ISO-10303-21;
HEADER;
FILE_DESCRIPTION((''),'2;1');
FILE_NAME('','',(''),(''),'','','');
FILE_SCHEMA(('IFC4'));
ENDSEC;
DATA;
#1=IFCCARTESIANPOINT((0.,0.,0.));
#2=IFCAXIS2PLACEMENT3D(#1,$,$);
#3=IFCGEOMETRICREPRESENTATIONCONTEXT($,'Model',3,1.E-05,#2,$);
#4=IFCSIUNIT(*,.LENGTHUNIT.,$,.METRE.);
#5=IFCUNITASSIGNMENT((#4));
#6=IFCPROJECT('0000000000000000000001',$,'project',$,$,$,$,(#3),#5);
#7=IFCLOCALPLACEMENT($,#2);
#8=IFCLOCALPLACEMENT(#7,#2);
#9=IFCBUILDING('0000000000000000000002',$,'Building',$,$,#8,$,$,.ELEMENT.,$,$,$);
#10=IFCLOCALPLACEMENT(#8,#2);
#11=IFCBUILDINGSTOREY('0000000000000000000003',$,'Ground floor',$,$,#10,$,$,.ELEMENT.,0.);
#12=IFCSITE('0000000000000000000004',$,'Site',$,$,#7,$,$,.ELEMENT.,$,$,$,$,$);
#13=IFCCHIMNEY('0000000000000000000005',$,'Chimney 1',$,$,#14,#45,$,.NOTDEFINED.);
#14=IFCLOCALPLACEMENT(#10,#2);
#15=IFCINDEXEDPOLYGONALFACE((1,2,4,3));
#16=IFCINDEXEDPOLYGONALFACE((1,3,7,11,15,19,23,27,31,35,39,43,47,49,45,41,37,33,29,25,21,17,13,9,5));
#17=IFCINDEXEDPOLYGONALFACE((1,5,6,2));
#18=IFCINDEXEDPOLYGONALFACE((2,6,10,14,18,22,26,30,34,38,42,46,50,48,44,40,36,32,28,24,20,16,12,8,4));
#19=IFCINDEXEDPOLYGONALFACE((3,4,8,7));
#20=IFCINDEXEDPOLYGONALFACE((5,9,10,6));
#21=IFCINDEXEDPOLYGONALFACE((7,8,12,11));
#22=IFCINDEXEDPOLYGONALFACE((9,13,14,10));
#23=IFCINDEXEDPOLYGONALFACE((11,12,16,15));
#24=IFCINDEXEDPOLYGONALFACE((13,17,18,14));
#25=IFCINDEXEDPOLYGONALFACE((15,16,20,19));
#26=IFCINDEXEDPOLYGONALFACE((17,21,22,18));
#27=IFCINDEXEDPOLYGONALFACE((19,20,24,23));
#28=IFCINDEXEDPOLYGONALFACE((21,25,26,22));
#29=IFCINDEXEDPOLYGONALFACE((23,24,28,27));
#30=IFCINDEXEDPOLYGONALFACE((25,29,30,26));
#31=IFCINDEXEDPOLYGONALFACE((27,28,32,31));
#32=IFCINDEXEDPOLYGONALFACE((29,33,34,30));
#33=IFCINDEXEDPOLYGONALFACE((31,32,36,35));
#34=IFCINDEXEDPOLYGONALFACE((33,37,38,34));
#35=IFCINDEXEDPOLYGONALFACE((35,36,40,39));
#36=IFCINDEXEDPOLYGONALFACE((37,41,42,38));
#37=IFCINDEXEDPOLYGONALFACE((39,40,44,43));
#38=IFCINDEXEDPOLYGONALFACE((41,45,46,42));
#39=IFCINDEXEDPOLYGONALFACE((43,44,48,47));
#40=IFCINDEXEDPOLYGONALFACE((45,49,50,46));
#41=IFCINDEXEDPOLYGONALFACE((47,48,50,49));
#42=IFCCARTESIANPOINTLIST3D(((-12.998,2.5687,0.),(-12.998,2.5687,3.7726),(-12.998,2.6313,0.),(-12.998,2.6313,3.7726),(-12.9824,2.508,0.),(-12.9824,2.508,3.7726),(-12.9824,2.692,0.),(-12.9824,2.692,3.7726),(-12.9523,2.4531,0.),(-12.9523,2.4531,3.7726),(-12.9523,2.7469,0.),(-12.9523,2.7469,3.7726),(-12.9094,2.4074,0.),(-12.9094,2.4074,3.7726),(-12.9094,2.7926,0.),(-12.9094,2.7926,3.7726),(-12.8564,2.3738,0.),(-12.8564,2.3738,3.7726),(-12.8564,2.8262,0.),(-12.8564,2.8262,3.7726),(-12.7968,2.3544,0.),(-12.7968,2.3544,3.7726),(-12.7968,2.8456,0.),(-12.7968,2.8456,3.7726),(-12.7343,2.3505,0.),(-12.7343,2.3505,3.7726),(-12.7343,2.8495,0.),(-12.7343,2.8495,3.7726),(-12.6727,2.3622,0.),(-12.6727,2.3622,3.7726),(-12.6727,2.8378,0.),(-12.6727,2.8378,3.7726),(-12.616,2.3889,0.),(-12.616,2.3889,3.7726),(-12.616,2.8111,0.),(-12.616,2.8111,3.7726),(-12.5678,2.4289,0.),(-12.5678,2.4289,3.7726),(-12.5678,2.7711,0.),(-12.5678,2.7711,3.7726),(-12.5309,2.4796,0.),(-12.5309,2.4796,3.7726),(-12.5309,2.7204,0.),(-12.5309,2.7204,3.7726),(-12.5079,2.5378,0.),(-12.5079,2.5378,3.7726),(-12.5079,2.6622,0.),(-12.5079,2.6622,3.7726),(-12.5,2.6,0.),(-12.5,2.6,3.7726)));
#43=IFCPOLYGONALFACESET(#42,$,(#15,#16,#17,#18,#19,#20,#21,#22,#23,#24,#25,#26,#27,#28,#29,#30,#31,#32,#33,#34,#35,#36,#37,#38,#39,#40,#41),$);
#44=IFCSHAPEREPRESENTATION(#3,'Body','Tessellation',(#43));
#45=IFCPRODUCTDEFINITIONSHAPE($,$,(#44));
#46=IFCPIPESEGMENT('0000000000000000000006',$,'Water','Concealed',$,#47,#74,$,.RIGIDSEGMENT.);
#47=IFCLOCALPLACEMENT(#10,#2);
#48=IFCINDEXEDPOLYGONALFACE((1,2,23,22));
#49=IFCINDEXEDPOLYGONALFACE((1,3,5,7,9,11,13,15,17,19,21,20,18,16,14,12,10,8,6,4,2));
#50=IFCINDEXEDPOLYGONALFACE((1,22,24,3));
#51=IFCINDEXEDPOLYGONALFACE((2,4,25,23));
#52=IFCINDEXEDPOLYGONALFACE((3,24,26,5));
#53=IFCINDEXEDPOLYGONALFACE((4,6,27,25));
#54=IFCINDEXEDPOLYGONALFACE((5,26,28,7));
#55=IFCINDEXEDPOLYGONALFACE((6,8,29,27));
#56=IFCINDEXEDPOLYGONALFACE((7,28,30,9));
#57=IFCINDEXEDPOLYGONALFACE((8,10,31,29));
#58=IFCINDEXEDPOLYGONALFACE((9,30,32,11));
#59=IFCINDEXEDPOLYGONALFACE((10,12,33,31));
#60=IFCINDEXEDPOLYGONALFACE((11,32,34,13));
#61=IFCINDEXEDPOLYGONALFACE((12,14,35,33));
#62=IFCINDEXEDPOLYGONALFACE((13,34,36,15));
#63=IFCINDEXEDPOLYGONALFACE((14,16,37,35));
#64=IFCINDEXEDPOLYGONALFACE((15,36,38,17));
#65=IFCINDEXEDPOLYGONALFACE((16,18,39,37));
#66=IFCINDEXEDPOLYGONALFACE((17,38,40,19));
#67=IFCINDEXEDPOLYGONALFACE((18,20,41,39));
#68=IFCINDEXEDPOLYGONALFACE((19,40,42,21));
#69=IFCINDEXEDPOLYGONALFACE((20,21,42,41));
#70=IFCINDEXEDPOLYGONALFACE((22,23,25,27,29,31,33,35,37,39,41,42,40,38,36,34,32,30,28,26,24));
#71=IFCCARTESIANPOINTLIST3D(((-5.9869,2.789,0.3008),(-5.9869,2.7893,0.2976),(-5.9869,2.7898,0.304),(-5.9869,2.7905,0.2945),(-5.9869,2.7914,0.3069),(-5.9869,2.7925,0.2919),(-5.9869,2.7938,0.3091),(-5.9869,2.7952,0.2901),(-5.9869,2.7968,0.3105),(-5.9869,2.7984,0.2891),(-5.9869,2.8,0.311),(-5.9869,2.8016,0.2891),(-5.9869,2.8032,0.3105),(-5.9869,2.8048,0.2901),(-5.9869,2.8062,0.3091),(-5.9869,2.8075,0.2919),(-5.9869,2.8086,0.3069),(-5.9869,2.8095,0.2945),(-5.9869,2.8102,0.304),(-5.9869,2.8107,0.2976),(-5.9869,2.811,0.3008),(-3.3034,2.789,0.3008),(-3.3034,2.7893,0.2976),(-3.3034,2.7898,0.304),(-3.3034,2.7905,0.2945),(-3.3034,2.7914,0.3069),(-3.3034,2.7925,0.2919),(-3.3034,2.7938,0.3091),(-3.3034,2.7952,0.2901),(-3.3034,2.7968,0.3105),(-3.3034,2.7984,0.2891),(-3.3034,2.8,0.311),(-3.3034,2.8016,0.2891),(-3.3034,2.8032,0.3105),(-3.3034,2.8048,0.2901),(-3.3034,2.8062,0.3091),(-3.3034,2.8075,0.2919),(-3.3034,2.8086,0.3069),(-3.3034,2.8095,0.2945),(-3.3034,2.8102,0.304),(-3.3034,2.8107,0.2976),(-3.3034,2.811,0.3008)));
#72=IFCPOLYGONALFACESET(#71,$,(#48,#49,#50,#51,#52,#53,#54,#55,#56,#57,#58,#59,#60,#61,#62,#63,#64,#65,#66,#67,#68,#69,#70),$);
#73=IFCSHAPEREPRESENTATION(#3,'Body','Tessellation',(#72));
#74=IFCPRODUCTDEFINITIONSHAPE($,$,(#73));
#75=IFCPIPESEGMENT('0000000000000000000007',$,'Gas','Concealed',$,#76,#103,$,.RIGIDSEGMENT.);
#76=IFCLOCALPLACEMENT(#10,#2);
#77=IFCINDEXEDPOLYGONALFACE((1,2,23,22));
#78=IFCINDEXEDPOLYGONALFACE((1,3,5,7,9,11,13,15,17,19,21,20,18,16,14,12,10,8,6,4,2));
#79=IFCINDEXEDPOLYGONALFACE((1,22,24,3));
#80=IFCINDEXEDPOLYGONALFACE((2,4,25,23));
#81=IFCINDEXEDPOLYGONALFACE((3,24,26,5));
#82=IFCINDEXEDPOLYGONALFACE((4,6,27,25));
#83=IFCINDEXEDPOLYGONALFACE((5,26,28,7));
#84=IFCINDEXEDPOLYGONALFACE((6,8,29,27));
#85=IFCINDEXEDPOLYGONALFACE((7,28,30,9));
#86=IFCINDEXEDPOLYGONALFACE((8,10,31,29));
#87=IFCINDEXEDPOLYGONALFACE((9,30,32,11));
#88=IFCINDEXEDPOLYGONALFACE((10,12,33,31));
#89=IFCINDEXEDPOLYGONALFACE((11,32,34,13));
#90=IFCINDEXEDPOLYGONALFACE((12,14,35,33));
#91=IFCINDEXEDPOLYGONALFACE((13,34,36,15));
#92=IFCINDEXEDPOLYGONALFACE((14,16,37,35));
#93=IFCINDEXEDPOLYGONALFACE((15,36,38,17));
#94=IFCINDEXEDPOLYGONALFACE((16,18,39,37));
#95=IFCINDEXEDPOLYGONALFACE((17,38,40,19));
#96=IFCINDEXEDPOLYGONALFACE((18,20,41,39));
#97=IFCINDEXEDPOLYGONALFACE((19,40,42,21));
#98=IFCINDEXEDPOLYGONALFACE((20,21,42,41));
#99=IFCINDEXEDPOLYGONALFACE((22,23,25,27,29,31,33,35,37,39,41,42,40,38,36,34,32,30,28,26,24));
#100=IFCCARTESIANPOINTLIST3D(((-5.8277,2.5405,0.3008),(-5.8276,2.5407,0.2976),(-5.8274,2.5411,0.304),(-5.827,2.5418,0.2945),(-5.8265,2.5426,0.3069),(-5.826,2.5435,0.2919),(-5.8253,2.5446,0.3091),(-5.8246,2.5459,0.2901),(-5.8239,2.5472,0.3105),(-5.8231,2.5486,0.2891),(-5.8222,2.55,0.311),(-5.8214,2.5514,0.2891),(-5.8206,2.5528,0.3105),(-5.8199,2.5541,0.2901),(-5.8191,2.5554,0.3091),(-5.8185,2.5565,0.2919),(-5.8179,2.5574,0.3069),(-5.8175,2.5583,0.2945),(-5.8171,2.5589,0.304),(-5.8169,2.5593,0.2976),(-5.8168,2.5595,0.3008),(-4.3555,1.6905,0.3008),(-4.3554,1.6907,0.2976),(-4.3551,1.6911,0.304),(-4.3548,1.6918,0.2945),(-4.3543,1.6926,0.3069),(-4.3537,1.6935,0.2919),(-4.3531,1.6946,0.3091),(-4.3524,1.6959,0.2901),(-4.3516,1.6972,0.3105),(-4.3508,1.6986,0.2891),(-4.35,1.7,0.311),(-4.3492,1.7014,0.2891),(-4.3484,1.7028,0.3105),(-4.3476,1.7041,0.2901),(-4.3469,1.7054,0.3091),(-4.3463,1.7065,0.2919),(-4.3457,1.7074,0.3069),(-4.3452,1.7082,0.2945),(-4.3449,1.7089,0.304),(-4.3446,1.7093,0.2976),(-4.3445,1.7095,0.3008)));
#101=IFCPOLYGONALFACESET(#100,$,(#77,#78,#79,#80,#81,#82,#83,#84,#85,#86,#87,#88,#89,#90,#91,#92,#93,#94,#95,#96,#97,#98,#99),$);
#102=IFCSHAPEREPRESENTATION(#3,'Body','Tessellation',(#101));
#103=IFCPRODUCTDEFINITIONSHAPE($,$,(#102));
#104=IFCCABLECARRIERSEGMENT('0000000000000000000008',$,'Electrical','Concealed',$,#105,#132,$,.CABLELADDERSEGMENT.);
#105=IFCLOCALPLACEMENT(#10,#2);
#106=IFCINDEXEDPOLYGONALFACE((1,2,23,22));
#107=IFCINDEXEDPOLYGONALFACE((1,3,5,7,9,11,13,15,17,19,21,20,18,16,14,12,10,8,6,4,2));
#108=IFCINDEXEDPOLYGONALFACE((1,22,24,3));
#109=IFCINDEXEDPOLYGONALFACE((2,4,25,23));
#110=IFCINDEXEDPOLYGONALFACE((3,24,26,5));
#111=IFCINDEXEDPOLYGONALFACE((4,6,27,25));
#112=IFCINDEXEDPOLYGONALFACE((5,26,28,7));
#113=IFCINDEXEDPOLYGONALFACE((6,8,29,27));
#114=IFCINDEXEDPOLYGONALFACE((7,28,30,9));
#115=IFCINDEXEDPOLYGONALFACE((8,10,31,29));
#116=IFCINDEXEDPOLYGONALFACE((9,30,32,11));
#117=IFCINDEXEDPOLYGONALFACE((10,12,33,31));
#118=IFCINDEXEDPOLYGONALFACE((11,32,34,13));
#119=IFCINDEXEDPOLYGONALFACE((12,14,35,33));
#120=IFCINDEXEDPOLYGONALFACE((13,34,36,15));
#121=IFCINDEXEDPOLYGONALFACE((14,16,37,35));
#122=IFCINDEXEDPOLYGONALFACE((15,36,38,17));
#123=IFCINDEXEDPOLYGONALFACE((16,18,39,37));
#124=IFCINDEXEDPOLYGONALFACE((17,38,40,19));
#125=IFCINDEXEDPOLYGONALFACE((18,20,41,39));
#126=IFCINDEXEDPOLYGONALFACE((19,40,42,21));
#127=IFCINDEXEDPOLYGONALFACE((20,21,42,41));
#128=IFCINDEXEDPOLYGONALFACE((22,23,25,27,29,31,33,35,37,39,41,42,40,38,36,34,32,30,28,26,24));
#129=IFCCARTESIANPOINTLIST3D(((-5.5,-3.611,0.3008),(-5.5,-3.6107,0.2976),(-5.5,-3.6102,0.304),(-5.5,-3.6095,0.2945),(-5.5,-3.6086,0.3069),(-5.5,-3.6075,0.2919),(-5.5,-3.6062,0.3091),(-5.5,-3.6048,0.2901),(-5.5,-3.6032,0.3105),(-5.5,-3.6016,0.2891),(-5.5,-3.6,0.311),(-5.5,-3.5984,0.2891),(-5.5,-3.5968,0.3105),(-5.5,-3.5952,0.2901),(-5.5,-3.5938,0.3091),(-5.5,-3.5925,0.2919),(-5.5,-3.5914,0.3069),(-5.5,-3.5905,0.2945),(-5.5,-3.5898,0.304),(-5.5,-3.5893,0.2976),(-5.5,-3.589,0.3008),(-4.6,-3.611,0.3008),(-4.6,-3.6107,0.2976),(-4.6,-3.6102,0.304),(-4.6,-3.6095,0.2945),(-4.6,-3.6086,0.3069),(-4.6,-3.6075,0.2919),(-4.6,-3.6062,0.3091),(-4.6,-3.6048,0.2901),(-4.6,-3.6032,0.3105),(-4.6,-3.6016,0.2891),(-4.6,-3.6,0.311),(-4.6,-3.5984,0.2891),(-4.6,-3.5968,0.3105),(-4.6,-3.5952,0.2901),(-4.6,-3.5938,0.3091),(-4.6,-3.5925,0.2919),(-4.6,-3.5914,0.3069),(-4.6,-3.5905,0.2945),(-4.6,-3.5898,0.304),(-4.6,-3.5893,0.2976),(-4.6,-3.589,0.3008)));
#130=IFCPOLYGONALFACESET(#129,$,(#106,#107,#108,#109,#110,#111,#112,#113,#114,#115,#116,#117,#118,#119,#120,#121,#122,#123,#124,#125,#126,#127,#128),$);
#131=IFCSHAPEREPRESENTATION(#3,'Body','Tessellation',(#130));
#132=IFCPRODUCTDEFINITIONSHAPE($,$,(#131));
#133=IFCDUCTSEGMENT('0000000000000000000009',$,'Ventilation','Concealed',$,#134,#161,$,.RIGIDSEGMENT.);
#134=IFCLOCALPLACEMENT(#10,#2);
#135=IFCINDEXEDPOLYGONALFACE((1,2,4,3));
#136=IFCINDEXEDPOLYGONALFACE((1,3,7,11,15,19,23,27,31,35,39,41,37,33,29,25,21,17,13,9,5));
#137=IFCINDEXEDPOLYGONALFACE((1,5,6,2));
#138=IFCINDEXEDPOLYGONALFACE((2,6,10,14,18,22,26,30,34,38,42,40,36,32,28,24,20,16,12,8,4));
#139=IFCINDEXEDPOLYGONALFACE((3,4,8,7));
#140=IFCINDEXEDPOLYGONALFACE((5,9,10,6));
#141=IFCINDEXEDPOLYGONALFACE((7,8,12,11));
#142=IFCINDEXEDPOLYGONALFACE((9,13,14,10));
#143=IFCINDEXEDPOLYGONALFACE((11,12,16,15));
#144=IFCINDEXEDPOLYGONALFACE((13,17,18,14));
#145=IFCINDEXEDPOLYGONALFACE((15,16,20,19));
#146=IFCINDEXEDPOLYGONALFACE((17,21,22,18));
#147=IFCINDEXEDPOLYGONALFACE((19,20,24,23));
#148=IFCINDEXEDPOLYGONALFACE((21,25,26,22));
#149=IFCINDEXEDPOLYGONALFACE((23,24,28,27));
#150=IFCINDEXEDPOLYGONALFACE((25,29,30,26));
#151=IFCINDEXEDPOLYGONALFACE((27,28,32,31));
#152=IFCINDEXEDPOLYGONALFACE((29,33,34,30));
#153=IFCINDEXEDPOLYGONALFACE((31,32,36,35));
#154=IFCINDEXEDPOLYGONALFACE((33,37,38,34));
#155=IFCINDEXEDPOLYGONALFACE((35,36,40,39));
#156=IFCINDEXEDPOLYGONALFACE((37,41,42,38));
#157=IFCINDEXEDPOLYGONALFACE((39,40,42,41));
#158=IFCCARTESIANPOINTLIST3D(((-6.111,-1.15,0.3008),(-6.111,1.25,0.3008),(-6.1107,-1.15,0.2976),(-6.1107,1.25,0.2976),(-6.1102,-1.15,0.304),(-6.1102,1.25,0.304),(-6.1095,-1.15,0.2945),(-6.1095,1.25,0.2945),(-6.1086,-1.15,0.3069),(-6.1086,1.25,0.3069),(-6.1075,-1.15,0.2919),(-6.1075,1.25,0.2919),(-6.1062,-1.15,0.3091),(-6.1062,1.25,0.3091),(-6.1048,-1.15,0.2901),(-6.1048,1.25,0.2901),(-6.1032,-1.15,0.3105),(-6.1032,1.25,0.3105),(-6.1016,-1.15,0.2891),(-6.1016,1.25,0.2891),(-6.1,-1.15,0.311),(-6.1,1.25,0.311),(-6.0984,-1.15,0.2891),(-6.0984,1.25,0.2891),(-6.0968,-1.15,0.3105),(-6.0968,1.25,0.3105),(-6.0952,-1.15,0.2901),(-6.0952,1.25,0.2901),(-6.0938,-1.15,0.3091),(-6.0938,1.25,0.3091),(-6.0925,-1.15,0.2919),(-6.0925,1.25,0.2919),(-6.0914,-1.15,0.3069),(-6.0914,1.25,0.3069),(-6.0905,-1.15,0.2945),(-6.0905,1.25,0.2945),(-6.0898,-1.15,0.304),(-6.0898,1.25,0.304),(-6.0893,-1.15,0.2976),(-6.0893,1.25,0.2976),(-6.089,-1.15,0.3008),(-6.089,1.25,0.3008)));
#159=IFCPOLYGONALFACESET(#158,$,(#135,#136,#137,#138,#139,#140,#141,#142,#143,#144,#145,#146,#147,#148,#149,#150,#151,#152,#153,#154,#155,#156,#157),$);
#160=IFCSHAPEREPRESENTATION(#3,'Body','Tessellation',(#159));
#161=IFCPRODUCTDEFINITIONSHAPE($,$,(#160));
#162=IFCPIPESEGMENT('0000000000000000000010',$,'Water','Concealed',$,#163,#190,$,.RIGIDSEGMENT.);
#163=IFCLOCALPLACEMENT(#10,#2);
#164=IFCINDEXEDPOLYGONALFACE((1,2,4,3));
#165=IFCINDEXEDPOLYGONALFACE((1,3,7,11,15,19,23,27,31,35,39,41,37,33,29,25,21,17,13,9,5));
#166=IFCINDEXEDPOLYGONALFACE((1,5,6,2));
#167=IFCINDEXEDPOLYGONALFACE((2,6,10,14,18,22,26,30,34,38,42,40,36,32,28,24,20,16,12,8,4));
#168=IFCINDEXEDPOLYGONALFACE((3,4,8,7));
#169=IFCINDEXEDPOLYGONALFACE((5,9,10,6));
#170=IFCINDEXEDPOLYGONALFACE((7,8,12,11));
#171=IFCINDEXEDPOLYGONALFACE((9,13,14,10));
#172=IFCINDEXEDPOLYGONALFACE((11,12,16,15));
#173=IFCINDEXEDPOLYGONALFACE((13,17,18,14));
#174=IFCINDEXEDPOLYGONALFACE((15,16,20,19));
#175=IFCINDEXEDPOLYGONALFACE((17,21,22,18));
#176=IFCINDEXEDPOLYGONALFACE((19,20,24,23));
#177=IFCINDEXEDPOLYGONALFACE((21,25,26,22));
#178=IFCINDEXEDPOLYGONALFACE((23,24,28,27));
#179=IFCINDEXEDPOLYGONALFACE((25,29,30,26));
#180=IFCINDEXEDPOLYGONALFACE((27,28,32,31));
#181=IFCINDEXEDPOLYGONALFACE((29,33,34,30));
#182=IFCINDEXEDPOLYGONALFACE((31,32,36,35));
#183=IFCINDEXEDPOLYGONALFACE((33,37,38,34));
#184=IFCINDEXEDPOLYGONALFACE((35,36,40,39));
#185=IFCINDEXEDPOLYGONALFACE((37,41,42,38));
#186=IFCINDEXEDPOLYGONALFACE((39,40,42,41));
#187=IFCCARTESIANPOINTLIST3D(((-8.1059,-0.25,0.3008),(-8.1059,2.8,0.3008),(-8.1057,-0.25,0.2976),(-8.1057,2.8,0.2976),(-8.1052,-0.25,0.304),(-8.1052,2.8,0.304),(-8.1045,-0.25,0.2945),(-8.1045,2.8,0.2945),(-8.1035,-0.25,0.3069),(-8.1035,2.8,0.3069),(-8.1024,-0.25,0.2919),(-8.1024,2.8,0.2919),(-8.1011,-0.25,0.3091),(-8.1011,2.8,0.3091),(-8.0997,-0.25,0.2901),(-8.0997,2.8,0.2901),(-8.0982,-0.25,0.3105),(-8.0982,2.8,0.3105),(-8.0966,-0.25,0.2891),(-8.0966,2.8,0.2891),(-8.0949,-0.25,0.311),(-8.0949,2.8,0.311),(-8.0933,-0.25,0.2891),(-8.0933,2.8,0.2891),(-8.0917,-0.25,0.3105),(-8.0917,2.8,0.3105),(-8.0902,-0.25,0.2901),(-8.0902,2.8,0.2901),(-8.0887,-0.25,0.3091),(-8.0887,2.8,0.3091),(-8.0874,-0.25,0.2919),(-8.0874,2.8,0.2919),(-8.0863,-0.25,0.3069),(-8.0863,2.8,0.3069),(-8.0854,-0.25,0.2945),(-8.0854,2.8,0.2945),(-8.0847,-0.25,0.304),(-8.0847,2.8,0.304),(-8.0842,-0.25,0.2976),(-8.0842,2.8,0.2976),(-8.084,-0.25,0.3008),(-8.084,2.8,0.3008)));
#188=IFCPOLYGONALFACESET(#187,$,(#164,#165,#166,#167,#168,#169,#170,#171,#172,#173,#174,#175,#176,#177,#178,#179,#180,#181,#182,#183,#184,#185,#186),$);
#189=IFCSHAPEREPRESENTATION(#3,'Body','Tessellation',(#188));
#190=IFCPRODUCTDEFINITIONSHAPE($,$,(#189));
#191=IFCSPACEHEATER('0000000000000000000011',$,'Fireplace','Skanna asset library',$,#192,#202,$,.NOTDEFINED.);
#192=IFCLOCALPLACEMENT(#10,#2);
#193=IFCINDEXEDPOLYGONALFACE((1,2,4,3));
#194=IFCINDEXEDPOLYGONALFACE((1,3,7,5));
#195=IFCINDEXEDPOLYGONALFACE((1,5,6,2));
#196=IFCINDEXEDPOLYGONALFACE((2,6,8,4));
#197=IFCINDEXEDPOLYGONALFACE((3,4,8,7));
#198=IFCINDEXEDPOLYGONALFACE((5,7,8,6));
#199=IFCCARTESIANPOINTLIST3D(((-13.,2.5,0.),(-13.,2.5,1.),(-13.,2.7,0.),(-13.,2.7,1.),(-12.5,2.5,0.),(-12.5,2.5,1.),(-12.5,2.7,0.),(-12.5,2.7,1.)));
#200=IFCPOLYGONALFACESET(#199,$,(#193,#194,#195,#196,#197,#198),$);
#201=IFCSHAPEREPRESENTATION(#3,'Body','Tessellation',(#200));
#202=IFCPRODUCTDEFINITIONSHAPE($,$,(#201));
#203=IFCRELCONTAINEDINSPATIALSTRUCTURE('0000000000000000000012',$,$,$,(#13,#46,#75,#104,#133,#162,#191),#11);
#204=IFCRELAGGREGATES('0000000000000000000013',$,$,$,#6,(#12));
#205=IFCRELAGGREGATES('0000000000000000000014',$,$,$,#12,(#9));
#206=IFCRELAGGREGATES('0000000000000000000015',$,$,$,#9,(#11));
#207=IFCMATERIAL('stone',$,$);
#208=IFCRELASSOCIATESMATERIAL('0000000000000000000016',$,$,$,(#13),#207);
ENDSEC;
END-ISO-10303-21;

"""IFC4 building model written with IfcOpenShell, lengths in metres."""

from ifc_helpers import new_model, si_unit, frame, origin, origin_2d, place, context, project, spatial, rectangle, circle, extrude, material, element, save


model = new_model("IFC4")

# Units and contexts
model_context = context("Model", 3, precision=1e-05, world=origin())
ifc_project = project(units=[si_unit("LENGTHUNIT", "METRE")], contexts=[model_context])

# Site, building, storey
site_placement = place(None, origin())
site = spatial("IfcSite", under=ifc_project, at=site_placement, Name="Site", CompositionType="ELEMENT")
building_placement = place(site_placement, origin())
building = spatial("IfcBuilding", under=site, at=building_placement, Name="Building", CompositionType="ELEMENT")
storey_placement = place(building_placement, origin())
storey = spatial("IfcBuildingStorey", under=building, at=storey_placement, Name="Ground floor", CompositionType="ELEMENT", Elevation=0.0)

# Chimney
ifc_material_1 = material(Name="stone")
chimney_placement = place(storey_placement, frame((-12.75, 2.6, 0.0), z_axis=(0.0, 0.0, 1.0), x_axis=(1.0, 0.0, 0.0)))
element("IfcChimney", 1, at=chimney_placement, inside=storey, material=ifc_material_1, Name="Chimney 1", PredefinedType="NOTDEFINED", context=model_context, shape_type="SweptSolid", body=[
    extrude(circle(Radius=0.25, at=origin_2d()), origin(), (0.0, 0.0, 1.0), 3.7726),
])

# Pipe segments
pipe_segment_1_placement = place(storey_placement, frame((-5.9869, 2.8, 0.3), z_axis=(1.0, 0.0, 0.0), x_axis=(0.0, 0.0, 1.0)))
element("IfcPipeSegment", 2, at=pipe_segment_1_placement, inside=storey, Name="Water", Description="Concealed", PredefinedType="RIGIDSEGMENT", context=model_context, shape_type="SweptSolid", body=[
    extrude(circle(Radius=0.011, at=origin_2d()), origin(), (0.0, 0.0, 1.0), 2.6834),
])
pipe_segment_2_placement = place(storey_placement, frame((-4.35, 1.7, 0.3), z_axis=(-0.866025, 0.5, 0.0), x_axis=(0.0, 0.0, 1.0)))
element("IfcPipeSegment", 3, at=pipe_segment_2_placement, inside=storey, Name="Gas", Description="Concealed", PredefinedType="RIGIDSEGMENT", context=model_context, shape_type="SweptSolid", body=[
    extrude(circle(Radius=0.011, at=origin_2d()), origin(), (0.0, 0.0, 1.0), 1.7),
])

# Cable carrier segment
cable_carrier_segment_placement = place(storey_placement, frame((-4.6, -3.6, 0.3), z_axis=(-1.0, 0.0, 0.0), x_axis=(0.0, 0.0, 1.0)))
element("IfcCableCarrierSegment", 4, at=cable_carrier_segment_placement, inside=storey, Name="Electrical", Description="Concealed", PredefinedType="CABLELADDERSEGMENT", context=model_context, shape_type="SweptSolid", body=[
    extrude(circle(Radius=0.011, at=origin_2d()), origin(), (0.0, 0.0, 1.0), 0.9),
])

# Duct segment
duct_segment_placement = place(storey_placement, frame((-6.1, 1.25, 0.3), z_axis=(0.0, -1.0, 0.0), x_axis=(0.0, 0.0, 1.0)))
element("IfcDuctSegment", 5, at=duct_segment_placement, inside=storey, Name="Ventilation", Description="Concealed", PredefinedType="RIGIDSEGMENT", context=model_context, shape_type="SweptSolid", body=[
    extrude(circle(Radius=0.011, at=origin_2d()), origin(), (0.0, 0.0, 1.0), 2.4),
])

# Pipe segment
pipe_segment_3_placement = place(storey_placement, frame((-8.0949, 2.8, 0.3), z_axis=(0.0, -1.0, 0.0), x_axis=(0.0, 0.0, 1.0)))
element("IfcPipeSegment", 6, at=pipe_segment_3_placement, inside=storey, Name="Water", Description="Concealed", PredefinedType="RIGIDSEGMENT", context=model_context, shape_type="SweptSolid", body=[
    extrude(circle(Radius=0.011, at=origin_2d()), origin(), (0.0, 0.0, 1.0), 3.05),
])

# Space heater
space_heater_placement = place(storey_placement, frame((-12.75, 2.6, 0.0), z_axis=(0.0, 0.0, 1.0), x_axis=(1.0, 0.0, 0.0)))
element("IfcSpaceHeater", 7, at=space_heater_placement, inside=storey, Name="Fireplace", Description="Skanna asset library", PredefinedType="NOTDEFINED", context=model_context, shape_type="SweptSolid", body=[
    extrude(rectangle(XDim=0.5, YDim=0.2, at=origin_2d()), origin(), (0.0, 0.0, 1.0), 1.0),
])

save(model, "model.ifc")
